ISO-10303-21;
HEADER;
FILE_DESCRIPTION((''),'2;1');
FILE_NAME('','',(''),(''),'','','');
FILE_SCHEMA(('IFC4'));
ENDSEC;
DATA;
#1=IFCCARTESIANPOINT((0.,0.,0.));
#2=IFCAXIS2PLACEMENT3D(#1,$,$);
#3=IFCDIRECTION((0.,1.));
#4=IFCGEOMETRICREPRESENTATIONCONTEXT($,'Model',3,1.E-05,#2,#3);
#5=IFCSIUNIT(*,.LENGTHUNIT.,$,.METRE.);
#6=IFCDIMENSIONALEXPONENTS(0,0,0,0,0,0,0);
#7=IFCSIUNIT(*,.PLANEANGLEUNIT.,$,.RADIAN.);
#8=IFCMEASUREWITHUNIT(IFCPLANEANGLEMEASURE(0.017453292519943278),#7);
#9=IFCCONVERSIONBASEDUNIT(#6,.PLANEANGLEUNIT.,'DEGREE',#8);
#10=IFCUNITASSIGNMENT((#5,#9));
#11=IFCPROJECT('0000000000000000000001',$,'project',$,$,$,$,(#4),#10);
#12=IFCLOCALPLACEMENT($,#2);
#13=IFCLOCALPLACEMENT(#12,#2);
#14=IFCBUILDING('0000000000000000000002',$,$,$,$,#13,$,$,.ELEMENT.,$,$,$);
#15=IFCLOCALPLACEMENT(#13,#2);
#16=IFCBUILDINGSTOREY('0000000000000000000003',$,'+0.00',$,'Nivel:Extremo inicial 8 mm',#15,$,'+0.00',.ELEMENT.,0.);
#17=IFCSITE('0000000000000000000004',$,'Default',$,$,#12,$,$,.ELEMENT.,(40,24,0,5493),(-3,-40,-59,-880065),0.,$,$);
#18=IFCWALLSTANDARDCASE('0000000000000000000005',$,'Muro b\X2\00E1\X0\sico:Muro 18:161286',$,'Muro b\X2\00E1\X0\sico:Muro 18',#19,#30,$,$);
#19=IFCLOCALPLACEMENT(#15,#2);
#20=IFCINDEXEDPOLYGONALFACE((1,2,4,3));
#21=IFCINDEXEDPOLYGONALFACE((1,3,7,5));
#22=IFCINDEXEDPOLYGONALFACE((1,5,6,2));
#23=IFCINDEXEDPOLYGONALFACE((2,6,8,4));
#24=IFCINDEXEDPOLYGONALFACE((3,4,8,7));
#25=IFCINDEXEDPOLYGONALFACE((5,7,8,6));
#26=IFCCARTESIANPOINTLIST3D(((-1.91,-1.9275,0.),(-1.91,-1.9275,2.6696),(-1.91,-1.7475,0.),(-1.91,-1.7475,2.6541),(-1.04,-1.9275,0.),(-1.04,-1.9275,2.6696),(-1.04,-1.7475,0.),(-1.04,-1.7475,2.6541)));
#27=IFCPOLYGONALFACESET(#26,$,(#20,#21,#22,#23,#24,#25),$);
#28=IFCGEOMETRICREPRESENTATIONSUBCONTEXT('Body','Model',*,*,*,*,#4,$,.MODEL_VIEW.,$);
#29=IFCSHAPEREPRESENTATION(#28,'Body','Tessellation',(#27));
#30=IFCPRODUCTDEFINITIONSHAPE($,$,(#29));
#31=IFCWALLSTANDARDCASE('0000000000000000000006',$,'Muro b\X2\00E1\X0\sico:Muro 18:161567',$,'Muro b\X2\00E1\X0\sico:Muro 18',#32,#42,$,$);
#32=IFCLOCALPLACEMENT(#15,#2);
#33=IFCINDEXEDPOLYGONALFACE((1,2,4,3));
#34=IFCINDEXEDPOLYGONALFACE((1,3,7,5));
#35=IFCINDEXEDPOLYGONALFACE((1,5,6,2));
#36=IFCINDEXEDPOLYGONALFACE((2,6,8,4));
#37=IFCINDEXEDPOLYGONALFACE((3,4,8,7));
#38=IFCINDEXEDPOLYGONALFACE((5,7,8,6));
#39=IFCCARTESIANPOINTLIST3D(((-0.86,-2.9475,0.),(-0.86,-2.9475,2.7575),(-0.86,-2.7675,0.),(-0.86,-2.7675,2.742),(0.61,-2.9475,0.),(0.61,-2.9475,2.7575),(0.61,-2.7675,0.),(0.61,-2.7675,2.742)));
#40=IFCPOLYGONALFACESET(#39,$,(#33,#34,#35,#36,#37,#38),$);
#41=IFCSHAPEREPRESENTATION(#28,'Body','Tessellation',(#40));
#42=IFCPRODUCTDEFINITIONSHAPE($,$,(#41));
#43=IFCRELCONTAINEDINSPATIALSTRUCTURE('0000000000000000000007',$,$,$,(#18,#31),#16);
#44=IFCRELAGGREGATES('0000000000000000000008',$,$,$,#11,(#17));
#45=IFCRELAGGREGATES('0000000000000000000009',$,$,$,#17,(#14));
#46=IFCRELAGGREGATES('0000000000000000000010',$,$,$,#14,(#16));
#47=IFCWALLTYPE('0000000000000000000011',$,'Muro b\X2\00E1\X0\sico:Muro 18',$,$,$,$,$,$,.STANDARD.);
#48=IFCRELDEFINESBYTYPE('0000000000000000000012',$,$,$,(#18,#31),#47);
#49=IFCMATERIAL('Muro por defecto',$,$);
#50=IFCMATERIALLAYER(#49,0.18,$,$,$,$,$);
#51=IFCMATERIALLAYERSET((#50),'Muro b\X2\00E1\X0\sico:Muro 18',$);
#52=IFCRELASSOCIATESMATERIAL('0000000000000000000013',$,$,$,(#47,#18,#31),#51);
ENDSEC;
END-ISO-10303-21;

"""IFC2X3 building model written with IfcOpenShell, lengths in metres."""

from ifc_helpers import new_model, entity, si_unit, converted_unit, direction, frame, frame_2d, origin, place, context, subcontext, project, spatial, polyline, rectangle, extrude, clip, bounded_halfspace, material, layer, layer_set, layer_usage, type_object, element, save


model = new_model("IFC2X3")

# Units and contexts
model_context = context("Model", 3, precision=1e-05, world=origin(), true_north=direction((0.0, 1.0)))
body_context = subcontext(model_context, "Body", "Model", "MODEL_VIEW")
ifc_project = project(units=[si_unit("LENGTHUNIT", "METRE"), converted_unit("PLANEANGLEUNIT", "DEGREE", entity("IfcPlaneAngleMeasure", 0.017453292519943278), si_unit("PLANEANGLEUNIT", "RADIAN"), dimensions=[0, 0, 0, 0, 0, 0, 0])], contexts=[model_context])

# Site, building, storey
site_placement = place(None, origin())
site = spatial("IfcSite", under=ifc_project, at=site_placement, Name="Default", CompositionType="ELEMENT", RefLatitude=(40, 24, 0, 5493), RefLongitude=(-3, -40, -59, -880065), RefElevation=0.0)
building_placement = place(site_placement, origin())
building = spatial("IfcBuilding", under=site, at=building_placement, CompositionType="ELEMENT")
storey_placement = place(building_placement, origin())
storey = spatial("IfcBuildingStorey", under=building, at=storey_placement, Name="+0.00", ObjectType="Nivel:Extremo inicial 8 mm", LongName="+0.00", CompositionType="ELEMENT", Elevation=0.0)

# Shared definitions
ifc_material_1 = material(Name="Muro por defecto")
ifc_layer = layer(ifc_material_1, 0.18)
ifc_layer_set = layer_set([ifc_layer], Name="Muro básico:Muro 18")
wall_type = type_object("IfcWallType", Name="Muro básico:Muro 18", PredefinedType="STANDARD", material=ifc_layer_set)

# Walls
ifc_layer_usage_1 = layer_usage(ifc_layer_set, "AXIS2", "NEGATIVE", 0.09)
wall_1_placement = place(storey_placement, frame((-1.91, -1.8375, 0.0)))
element("IfcWallStandardCase", 1, at=wall_1_placement, inside=storey, type_object=wall_type, material=ifc_layer_usage_1, Name="Muro básico:Muro 18:161286", ObjectType="Muro básico:Muro 18", context=body_context, shape_type="Clipping", body=[
    clip(extrude(rectangle(XDim=0.87, YDim=0.18, at=frame_2d((0.435, 0.0), x_axis=(-1.0, 0.0))), origin(), (0.0, 0.0, 1.0), 2.6696), bounded_halfspace(frame((0.0, -0.09, 2.6696), z_axis=(0.0, 0.085882, 0.996305), x_axis=(-1.0, 0.0, 0.0)), False, frame((0.0, -0.09, 2.6696)), polyline([(0.0, 0.0), (0.87, 0.0), (0.87, 0.18), (0.0, 0.18), (0.0, 0.0)]))),
])
ifc_layer_usage_2 = layer_usage(ifc_layer_set, "AXIS2", "NEGATIVE", 0.09)
wall_2_placement = place(storey_placement, frame((-0.86, -2.8575, 0.0)))
element("IfcWallStandardCase", 2, at=wall_2_placement, inside=storey, type_object=wall_type, material=ifc_layer_usage_2, Name="Muro básico:Muro 18:161567", ObjectType="Muro básico:Muro 18", context=body_context, shape_type="Clipping", body=[
    clip(extrude(rectangle(XDim=1.47, YDim=0.18, at=frame_2d((0.735, 0.0), x_axis=(-1.0, 0.0))), origin(), (0.0, 0.0, 1.0), 2.7575), bounded_halfspace(frame((0.0, -0.09, 2.7575), z_axis=(0.0, 0.085882, 0.996305), x_axis=(-1.0, 0.0, 0.0)), False, frame((0.0, -0.09, 2.7575)), polyline([(0.0, 0.0), (1.47, 0.0), (1.47, 0.18), (0.0, 0.18), (0.0, 0.0)]))),
])

save(model, "model.ifc")
